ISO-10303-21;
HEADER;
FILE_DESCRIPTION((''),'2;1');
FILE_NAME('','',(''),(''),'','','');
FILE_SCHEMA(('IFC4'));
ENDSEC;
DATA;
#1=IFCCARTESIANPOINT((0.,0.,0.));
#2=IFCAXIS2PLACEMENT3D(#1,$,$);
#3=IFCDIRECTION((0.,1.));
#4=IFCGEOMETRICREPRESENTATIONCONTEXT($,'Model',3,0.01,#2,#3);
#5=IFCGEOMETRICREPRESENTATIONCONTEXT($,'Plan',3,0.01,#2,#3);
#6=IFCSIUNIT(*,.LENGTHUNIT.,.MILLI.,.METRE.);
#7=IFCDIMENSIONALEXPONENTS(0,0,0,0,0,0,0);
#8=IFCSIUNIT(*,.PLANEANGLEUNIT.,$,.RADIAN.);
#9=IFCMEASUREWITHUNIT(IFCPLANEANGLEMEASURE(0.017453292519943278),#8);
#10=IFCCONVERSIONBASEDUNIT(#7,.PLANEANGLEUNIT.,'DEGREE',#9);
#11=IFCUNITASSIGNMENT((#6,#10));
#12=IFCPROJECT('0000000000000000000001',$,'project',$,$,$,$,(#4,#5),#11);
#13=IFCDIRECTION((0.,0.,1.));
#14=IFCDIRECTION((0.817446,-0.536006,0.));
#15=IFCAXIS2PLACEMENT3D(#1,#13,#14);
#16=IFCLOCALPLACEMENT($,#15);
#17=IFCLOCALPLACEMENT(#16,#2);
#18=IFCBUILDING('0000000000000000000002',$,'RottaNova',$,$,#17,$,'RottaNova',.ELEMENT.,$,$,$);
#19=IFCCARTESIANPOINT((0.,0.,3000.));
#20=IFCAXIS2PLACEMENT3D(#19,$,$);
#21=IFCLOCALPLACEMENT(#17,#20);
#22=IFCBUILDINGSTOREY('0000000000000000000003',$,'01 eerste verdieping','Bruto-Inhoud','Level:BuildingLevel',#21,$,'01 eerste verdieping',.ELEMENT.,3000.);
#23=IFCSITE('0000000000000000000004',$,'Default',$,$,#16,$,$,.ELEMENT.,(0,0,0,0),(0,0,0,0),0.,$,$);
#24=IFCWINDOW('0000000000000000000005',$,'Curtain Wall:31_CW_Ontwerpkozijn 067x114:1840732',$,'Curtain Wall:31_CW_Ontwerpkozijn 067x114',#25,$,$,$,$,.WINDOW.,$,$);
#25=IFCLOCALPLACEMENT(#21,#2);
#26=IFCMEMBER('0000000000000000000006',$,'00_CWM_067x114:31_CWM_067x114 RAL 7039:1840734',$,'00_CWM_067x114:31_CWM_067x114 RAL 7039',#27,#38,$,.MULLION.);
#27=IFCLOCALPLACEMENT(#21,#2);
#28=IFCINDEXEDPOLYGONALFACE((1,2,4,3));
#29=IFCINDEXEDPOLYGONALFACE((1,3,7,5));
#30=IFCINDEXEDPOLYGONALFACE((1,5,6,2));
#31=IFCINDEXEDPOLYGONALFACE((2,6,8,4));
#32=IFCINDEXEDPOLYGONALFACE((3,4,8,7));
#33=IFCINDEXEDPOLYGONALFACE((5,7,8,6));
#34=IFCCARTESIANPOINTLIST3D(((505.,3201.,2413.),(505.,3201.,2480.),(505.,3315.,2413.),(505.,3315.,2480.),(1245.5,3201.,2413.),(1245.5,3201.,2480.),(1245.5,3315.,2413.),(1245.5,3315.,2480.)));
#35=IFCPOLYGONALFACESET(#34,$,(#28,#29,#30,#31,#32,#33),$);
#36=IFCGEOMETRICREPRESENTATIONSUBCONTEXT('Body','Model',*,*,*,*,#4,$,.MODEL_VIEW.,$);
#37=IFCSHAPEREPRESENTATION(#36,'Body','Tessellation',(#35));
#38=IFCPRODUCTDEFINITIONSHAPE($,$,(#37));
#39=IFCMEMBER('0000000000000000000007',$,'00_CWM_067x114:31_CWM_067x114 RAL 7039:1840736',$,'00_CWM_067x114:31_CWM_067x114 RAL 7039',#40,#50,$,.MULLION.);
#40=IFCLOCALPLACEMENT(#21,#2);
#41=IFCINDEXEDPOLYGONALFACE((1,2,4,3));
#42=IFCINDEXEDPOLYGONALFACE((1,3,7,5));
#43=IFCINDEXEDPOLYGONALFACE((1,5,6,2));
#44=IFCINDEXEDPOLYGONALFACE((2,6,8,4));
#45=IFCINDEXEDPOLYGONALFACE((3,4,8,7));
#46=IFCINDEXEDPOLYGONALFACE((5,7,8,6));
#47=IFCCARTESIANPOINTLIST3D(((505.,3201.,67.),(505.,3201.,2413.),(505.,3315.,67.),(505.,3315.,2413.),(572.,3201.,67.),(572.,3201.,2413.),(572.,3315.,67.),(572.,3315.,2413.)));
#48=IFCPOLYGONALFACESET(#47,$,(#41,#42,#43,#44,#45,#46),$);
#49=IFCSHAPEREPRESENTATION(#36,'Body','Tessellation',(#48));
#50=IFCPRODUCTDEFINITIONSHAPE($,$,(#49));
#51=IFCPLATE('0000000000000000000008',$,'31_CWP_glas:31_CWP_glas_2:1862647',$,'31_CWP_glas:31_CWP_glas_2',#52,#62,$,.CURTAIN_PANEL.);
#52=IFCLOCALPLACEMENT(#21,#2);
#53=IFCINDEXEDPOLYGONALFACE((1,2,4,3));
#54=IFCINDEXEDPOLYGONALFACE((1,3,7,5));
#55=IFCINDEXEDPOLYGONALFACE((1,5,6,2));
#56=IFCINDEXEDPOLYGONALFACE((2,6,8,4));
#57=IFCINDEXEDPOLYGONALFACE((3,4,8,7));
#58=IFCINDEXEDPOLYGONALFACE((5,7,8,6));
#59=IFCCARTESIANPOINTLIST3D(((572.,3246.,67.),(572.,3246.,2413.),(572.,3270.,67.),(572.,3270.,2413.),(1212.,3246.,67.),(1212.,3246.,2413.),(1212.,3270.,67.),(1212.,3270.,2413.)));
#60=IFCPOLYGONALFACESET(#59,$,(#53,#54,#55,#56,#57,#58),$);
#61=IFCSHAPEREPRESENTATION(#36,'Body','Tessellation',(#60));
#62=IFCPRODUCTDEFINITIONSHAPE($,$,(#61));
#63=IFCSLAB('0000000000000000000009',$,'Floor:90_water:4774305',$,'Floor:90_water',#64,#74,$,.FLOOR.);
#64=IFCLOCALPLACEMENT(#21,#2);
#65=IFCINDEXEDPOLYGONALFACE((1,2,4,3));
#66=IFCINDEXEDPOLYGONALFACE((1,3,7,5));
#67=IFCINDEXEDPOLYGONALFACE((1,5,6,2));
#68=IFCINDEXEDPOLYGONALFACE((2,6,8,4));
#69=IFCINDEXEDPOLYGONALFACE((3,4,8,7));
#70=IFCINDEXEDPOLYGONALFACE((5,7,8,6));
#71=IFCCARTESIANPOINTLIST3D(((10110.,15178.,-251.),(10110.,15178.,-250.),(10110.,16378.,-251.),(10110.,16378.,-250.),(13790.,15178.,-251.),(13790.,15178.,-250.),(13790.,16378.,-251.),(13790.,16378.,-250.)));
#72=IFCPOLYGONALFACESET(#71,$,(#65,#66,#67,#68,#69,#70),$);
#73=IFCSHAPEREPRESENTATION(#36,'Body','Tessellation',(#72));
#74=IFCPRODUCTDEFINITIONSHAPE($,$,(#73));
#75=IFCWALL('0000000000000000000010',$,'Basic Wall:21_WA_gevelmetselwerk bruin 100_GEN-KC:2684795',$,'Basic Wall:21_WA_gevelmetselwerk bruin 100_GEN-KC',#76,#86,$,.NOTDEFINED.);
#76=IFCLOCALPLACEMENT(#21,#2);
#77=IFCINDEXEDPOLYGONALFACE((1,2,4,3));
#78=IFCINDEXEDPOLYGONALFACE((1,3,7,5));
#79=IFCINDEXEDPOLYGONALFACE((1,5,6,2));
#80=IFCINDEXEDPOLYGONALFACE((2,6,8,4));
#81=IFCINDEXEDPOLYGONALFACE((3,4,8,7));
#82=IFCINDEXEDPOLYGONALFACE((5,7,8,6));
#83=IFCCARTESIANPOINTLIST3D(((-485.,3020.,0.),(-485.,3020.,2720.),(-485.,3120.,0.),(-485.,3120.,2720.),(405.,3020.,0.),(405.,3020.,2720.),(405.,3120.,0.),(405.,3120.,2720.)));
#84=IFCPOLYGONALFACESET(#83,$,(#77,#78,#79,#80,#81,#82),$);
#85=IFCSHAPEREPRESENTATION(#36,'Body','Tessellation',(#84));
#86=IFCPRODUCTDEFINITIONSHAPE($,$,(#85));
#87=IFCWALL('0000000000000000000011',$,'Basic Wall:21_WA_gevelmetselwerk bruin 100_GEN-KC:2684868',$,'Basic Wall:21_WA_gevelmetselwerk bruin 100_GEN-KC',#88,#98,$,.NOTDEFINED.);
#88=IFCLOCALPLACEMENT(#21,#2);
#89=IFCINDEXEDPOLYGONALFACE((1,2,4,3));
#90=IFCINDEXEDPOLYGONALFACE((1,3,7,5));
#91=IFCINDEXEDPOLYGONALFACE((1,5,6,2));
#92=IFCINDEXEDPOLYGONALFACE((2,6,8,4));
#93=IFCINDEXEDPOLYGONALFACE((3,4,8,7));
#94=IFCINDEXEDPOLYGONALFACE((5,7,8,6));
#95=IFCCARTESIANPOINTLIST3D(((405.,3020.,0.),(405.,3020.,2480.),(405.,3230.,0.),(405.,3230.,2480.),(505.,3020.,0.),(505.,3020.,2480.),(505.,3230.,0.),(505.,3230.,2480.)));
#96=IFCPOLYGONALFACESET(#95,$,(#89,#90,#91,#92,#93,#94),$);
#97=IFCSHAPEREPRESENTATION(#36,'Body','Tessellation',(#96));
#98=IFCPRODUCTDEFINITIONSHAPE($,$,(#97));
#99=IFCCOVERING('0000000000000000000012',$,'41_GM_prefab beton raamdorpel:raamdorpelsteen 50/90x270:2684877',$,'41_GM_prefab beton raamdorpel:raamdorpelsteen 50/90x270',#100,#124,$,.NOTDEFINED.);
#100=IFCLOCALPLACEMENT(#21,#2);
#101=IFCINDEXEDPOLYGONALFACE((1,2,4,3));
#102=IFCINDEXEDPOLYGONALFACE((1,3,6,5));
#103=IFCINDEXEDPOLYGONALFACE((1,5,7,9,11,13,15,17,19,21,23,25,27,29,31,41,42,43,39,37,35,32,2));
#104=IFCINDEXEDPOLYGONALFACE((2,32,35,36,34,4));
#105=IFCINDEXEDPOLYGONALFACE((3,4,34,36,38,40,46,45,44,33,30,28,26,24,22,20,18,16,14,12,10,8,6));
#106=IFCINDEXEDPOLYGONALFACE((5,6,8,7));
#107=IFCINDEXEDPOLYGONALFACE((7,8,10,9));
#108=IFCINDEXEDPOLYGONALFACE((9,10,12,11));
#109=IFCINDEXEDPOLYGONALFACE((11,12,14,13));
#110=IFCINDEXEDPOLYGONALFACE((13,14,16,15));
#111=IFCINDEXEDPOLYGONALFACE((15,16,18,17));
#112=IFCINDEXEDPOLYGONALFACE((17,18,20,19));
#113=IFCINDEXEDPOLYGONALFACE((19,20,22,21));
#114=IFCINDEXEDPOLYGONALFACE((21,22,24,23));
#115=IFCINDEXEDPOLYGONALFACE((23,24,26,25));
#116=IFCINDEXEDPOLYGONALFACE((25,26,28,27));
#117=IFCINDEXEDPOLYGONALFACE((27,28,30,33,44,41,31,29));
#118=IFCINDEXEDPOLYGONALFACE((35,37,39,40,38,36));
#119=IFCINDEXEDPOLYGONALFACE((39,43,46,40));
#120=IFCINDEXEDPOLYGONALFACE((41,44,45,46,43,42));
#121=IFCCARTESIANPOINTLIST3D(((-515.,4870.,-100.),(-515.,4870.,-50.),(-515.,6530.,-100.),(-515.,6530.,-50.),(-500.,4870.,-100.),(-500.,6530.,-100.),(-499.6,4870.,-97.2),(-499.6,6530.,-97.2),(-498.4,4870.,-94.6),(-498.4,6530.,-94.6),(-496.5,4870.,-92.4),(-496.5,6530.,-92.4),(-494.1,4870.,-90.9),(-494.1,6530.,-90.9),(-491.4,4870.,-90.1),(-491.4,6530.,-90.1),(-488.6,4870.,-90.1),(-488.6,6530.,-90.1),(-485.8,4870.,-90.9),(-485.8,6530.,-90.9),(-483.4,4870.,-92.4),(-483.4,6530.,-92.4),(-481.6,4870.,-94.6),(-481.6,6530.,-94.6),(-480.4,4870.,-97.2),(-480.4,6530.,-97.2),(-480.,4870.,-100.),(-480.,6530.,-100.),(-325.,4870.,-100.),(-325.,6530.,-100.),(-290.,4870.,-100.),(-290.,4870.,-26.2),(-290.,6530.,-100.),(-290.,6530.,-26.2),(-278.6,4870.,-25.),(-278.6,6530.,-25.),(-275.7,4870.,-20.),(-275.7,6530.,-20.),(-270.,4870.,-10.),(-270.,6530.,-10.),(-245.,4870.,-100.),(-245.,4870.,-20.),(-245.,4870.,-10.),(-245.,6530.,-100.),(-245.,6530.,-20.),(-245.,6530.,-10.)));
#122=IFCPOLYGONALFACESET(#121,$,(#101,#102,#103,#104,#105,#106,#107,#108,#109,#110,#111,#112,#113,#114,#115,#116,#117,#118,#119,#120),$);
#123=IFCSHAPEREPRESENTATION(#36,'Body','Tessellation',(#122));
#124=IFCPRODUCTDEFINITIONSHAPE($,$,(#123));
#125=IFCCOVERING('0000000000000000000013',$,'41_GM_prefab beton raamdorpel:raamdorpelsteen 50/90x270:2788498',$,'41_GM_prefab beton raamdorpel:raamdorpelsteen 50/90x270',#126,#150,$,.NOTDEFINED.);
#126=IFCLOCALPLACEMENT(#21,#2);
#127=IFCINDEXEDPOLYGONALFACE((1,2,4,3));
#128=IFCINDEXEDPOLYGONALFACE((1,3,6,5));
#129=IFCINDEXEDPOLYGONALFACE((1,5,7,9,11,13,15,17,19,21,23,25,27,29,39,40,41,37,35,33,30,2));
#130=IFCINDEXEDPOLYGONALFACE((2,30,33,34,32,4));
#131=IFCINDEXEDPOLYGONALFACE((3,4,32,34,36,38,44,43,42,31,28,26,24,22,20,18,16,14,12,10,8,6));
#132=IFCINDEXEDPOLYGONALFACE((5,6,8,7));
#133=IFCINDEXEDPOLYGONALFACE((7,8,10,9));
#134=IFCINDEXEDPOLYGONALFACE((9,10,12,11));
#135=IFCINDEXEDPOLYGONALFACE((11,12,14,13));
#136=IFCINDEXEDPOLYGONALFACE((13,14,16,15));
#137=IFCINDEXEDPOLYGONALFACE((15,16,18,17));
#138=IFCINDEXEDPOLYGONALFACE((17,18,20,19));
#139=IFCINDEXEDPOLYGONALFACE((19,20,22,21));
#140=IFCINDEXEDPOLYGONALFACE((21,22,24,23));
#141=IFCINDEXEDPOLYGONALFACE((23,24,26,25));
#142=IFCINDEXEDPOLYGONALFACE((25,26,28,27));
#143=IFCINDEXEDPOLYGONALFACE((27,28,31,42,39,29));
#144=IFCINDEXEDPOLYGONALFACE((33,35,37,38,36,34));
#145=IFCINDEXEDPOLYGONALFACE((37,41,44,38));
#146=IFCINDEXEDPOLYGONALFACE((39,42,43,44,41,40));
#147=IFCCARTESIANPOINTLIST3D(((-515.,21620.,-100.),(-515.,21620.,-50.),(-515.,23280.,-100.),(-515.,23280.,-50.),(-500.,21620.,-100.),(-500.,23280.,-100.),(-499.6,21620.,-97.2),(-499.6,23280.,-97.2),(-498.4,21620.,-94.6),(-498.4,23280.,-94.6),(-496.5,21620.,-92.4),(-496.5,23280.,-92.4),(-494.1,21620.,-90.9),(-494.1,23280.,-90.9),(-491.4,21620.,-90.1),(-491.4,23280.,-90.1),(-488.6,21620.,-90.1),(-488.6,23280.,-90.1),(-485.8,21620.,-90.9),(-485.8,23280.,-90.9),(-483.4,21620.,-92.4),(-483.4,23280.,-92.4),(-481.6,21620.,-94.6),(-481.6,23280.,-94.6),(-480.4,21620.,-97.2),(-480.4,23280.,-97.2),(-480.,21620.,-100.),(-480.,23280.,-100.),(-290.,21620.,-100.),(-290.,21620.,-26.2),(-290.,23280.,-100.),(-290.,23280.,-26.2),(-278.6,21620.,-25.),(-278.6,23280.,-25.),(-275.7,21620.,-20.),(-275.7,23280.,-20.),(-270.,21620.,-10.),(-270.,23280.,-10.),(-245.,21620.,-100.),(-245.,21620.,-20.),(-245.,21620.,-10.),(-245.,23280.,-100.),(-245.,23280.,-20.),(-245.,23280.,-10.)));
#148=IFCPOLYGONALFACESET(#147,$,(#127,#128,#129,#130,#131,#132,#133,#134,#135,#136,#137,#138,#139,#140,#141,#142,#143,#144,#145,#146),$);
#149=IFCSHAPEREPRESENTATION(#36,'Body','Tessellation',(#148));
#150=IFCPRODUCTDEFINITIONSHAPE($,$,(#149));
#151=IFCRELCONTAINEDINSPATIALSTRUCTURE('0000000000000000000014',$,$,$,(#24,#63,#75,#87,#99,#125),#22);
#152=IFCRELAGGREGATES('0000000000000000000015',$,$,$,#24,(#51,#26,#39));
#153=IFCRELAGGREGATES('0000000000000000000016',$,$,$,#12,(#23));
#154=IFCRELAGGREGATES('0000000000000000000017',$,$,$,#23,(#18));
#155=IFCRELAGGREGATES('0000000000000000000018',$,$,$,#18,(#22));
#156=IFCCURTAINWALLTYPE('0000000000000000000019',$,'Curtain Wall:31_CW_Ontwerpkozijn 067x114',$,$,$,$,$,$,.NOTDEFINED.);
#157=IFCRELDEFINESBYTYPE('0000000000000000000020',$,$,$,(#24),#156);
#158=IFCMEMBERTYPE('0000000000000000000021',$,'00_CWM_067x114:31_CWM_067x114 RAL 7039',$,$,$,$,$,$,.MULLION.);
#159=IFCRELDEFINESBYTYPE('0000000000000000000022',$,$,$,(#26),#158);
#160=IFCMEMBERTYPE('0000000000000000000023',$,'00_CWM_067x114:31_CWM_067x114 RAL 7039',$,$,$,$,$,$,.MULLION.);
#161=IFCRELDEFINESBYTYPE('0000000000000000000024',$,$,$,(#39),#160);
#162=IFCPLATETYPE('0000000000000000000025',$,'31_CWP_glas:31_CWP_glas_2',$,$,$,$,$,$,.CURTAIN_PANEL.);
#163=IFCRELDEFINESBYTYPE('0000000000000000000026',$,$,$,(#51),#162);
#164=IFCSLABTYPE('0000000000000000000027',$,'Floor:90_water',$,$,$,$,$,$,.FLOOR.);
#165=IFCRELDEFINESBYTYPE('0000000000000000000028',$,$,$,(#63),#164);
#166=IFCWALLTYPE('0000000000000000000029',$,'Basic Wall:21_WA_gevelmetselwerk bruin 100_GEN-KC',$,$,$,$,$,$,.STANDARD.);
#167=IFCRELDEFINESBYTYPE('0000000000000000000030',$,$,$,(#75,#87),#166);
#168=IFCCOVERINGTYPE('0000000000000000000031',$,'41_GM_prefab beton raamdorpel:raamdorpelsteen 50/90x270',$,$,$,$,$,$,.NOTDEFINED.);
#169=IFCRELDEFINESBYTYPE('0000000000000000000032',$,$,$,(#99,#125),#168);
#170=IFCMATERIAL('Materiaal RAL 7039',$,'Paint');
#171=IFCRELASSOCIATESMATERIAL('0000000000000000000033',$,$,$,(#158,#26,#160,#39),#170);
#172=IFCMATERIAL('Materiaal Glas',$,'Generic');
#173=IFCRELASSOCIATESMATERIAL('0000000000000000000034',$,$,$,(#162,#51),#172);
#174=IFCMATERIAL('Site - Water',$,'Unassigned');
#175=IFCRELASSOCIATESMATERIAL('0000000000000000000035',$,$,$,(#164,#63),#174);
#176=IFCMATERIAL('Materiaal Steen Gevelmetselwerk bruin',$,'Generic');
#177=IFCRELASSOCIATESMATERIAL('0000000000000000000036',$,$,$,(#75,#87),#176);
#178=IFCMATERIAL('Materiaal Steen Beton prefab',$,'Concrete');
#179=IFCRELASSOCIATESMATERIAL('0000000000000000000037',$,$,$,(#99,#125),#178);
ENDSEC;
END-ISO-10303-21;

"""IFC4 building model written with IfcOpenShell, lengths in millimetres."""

from ifc_helpers import new_model, entity, si_unit, converted_unit, direction, frame, origin, place, context, subcontext, project, spatial, line, arc, indexed_curve, outline, extrude, source, transform, mapped, material, type_object, type_shapes, element, aggregate, save


model = new_model("IFC4")

# Units and contexts
model_context = context("Model", 3, precision=0.01, world=origin(), true_north=direction((0.0, 1.0)))
plan_context = context("Plan", 3, precision=0.01, world=origin(), true_north=direction((0.0, 1.0)))
body_context = subcontext(model_context, "Body", "Model", "MODEL_VIEW")
ifc_project = project(units=[si_unit("LENGTHUNIT", "METRE", prefix="MILLI"), converted_unit("PLANEANGLEUNIT", "DEGREE", entity("IfcPlaneAngleMeasure", 0.017453292519943278), si_unit("PLANEANGLEUNIT", "RADIAN"), dimensions=[0, 0, 0, 0, 0, 0, 0])], contexts=[model_context, plan_context])

# Site, building, storey
site_placement = place(None, frame((0.0, 0.0, 0.0), z_axis=(0.0, 0.0, 1.0), x_axis=(0.817446, -0.536006, 0.0)))
site = spatial("IfcSite", under=ifc_project, at=site_placement, Name="Default", CompositionType="ELEMENT", RefLatitude=(0, 0, 0, 0), RefLongitude=(0, 0, 0, 0), RefElevation=0.0)
building_placement = place(site_placement, origin())
building = spatial("IfcBuilding", under=site, at=building_placement, Name="RottaNova", LongName="RottaNova", CompositionType="ELEMENT")
storey_placement = place(building_placement, frame((0.0, 0.0, 3000.0)))
storey = spatial("IfcBuildingStorey", under=building, at=storey_placement, Name="01 eerste verdieping", Description="Bruto-Inhoud", ObjectType="Level:BuildingLevel", LongName="01 eerste verdieping", CompositionType="ELEMENT", Elevation=3000.0)

# Window, members
curtain_wall_type = type_object("IfcCurtainWallType", Name="Curtain Wall:31_CW_Ontwerpkozijn 067x114", PredefinedType="NOTDEFINED")
window_placement = place(storey_placement, frame((0.0, 0.0, -3000.0)))
window = element("IfcWindow", 1, at=window_placement, inside=storey, type_object=curtain_wall_type, Name="Curtain Wall:31_CW_Ontwerpkozijn 067x114:1840732", ObjectType="Curtain Wall:31_CW_Ontwerpkozijn 067x114", PredefinedType="WINDOW")
ifc_material_1 = material(Name="Materiaal RAL 7039", Category="Paint")
member_type_1 = type_object("IfcMemberType", Name="00_CWM_067x114:31_CWM_067x114 RAL 7039", PredefinedType="MULLION", material=ifc_material_1)
shared_shape_1 = source(origin(), body_context, "Body", "SweptSolid", [
    extrude(outline(indexed_curve([(-33.5, -57.0), (33.5, -57.0), (33.5, 57.0), (-33.5, 57.0), (-33.5, -57.0)], self_intersect=False)), frame((-33.5, -57.0, -740.5), z_axis=(0.0, 0.0, 1.0), x_axis=(-1.0, 0.0, 0.0)), (0.0, 0.0, 1.0), 740.5),
])
type_shapes(member_type_1, [shared_shape_1])
member_1_placement = place(window_placement, frame((505.0, 3315.0, 5480.0), z_axis=(-1.0, 0.0, 0.0), x_axis=(0.0, 0.0, 1.0)))
member_1 = element("IfcMember", 2, at=member_1_placement, type_object=member_type_1, material=ifc_material_1, Name="00_CWM_067x114:31_CWM_067x114 RAL 7039:1840734", ObjectType="00_CWM_067x114:31_CWM_067x114 RAL 7039", PredefinedType="MULLION", context=body_context, shape_type="MappedRepresentation", body=[
    mapped(shared_shape_1, transform((0.0, 0.0, 0.0), scale=1.0)),
])
member_type_2 = type_object("IfcMemberType", Name="00_CWM_067x114:31_CWM_067x114 RAL 7039", PredefinedType="MULLION", material=ifc_material_1)
shared_shape_2 = source(origin(), body_context, "Body", "SweptSolid", [
    extrude(outline(indexed_curve([(-33.5, -57.0), (33.5, -57.0), (33.5, 57.0), (-33.5, 57.0), (-33.5, -57.0)], self_intersect=False)), frame((-33.5, -57.0, -2346.0), z_axis=(0.0, 0.0, 1.0), x_axis=(-1.0, 0.0, 0.0)), (0.0, 0.0, 1.0), 2346.0),
])
type_shapes(member_type_2, [shared_shape_2])
member_2_placement = place(window_placement, frame((505.0, 3315.0, 3067.0), z_axis=(0.0, 0.0, -1.0), x_axis=(-1.0, 0.0, 0.0)))
member_2 = element("IfcMember", 3, at=member_2_placement, type_object=member_type_2, material=ifc_material_1, Name="00_CWM_067x114:31_CWM_067x114 RAL 7039:1840736", ObjectType="00_CWM_067x114:31_CWM_067x114 RAL 7039", PredefinedType="MULLION", context=body_context, shape_type="MappedRepresentation", body=[
    mapped(shared_shape_2, transform((0.0, 0.0, 0.0), scale=1.0)),
])

# Plate
ifc_material_2 = material(Name="Materiaal Glas", Category="Generic")
plate_type = type_object("IfcPlateType", Name="31_CWP_glas:31_CWP_glas_2", PredefinedType="CURTAIN_PANEL", material=ifc_material_2)
shared_shape_3 = source(origin(), body_context, "Body", "SweptSolid", [
    extrude(outline(indexed_curve([(-12.0, -320.0), (12.0, -320.0), (12.0, 320.0), (-12.0, 320.0), (-12.0, -320.0)], self_intersect=False)), frame((0.0, 57.0, 0.0), z_axis=(0.0, 0.0, 1.0), x_axis=(0.0, 1.0, 0.0)), (0.0, 0.0, 1.0), 2346.0),
])
type_shapes(plate_type, [shared_shape_3])
plate_placement = place(window_placement, frame((892.0, 3315.0, 3067.0), z_axis=(0.0, 0.0, 1.0), x_axis=(-1.0, 0.0, 0.0)))
plate = element("IfcPlate", 4, at=plate_placement, type_object=plate_type, material=ifc_material_2, Name="31_CWP_glas:31_CWP_glas_2:1862647", ObjectType="31_CWP_glas:31_CWP_glas_2", PredefinedType="CURTAIN_PANEL", context=body_context, shape_type="MappedRepresentation", body=[
    mapped(shared_shape_3, transform((0.0, 0.0, 0.0), scale=1.0)),
])
aggregate(window, [plate, member_1, member_2])

# Slab
ifc_material_3 = material(Name="Site - Water", Category="Unassigned")
slab_type_1 = type_object("IfcSlabType", Name="Floor:90_water", PredefinedType="FLOOR", material=ifc_material_3)
slab_1_placement = place(storey_placement, origin())
element("IfcSlab", 5, at=slab_1_placement, inside=storey, type_object=slab_type_1, material=ifc_material_3, Name="Floor:90_water:4774305", ObjectType="Floor:90_water", PredefinedType="FLOOR", context=body_context, shape_type="SweptSolid", body=[
    extrude(outline(indexed_curve([(-600.0, -1840.0), (600.0, -1840.0), (600.0, 1840.0), (-600.0, 1840.0), (-600.0, -1840.0)], self_intersect=False)), frame((11950.0, 15778.0, -250.0), z_axis=(0.0, 0.0, -1.0), x_axis=(0.0, 1.0, 0.0)), (0.0, 0.0, 1.0), 1.0),
])

# Walls
ifc_material_4 = material(Name="Materiaal Steen Gevelmetselwerk bruin", Category="Generic")
wall_type = type_object("IfcWallType", Name="Basic Wall:21_WA_gevelmetselwerk bruin 100_GEN-KC", PredefinedType="STANDARD")
wall_1_placement = place(storey_placement, frame((405.0, 3070.0, 0.0), z_axis=(0.0, 0.0, 1.0), x_axis=(-1.0, 0.0, 0.0)))
element("IfcWall", 6, at=wall_1_placement, inside=storey, type_object=wall_type, material=ifc_material_4, Name="Basic Wall:21_WA_gevelmetselwerk bruin 100_GEN-KC:2684795", ObjectType="Basic Wall:21_WA_gevelmetselwerk bruin 100_GEN-KC", PredefinedType="NOTDEFINED", context=body_context, shape_type="SweptSolid", body=[
    extrude(outline(indexed_curve([(890.0, 50.0), (0.0, 50.0), (0.0, -50.0), (890.0, -50.0), (890.0, 50.0)], self_intersect=False)), origin(), (0.0, 0.0, 1.0), 2720.0),
])
wall_2_placement = place(storey_placement, frame((455.0, 3230.0, 0.0), z_axis=(0.0, 0.0, 1.0), x_axis=(0.0, -1.0, 0.0)))
element("IfcWall", 7, at=wall_2_placement, inside=storey, type_object=wall_type, material=ifc_material_4, Name="Basic Wall:21_WA_gevelmetselwerk bruin 100_GEN-KC:2684868", ObjectType="Basic Wall:21_WA_gevelmetselwerk bruin 100_GEN-KC", PredefinedType="NOTDEFINED", context=body_context, shape_type="SweptSolid", body=[
    extrude(outline(indexed_curve([(210.0, 50.0), (0.0, 50.0), (0.0, -50.0), (210.0, -50.0), (210.0, 50.0)], self_intersect=False)), origin(), (0.0, 0.0, 1.0), 2480.0),
])

# Coverings
ifc_material_5 = material(Name="Materiaal Steen Beton prefab", Category="Concrete")
covering_type_1 = type_object("IfcCoveringType", Name="41_GM_prefab beton raamdorpel:raamdorpelsteen 50/90x270", PredefinedType="NOTDEFINED")
covering_1_placement = place(storey_placement, origin())
element("IfcCovering", 8, at=covering_1_placement, inside=storey, type_object=covering_type_1, material=ifc_material_5, Name="41_GM_prefab beton raamdorpel:raamdorpelsteen 50/90x270:2684877", ObjectType="41_GM_prefab beton raamdorpel:raamdorpelsteen 50/90x270", PredefinedType="NOTDEFINED", context=body_context, shape_type="SweptSolid", body=[
    extrude(outline(indexed_curve([(74.2, -48.6), (99.2, -48.6), (99.2, -38.6), (99.2, 41.4), (54.2, 41.4), (19.2, 41.4), (-135.8, 41.4), (-145.8, 31.4), (-155.8, 41.4), (-170.8, 41.4), (-170.8, -8.6), (54.2, -32.4), (65.5, -33.6), (68.4, -38.6)], segments=[line(1, 2, 3, 4, 5, 6, 7), arc(7, 8, 9), line(9, 10, 11, 12, 13, 14, 1)], self_intersect=False)), frame((-344.2, 4870.0, -58.6), z_axis=(0.0, 1.0, 0.0), x_axis=(1.0, 0.0, 0.0)), (0.0, 0.0, 1.0), 1660.0),
])
covering_2_placement = place(storey_placement, origin())
element("IfcCovering", 9, at=covering_2_placement, inside=storey, type_object=covering_type_1, material=ifc_material_5, Name="41_GM_prefab beton raamdorpel:raamdorpelsteen 50/90x270:2788498", ObjectType="41_GM_prefab beton raamdorpel:raamdorpelsteen 50/90x270", PredefinedType="NOTDEFINED", context=body_context, shape_type="SweptSolid", body=[
    extrude(outline(indexed_curve([(75.8, -45.1), (100.8, -45.1), (100.8, -35.1), (100.8, 44.9), (55.8, 44.9), (-134.2, 44.9), (-144.2, 34.9), (-154.2, 44.9), (-169.2, 44.9), (-169.2, -5.1), (55.8, -28.9), (67.1, -30.1), (70.0, -35.1)], segments=[line(1, 2, 3, 4, 5, 6), arc(6, 7, 8), line(8, 9, 10, 11, 12, 13, 1)], self_intersect=False)), frame((-345.8, 21620.0, -55.1), z_axis=(0.0, 1.0, 0.0), x_axis=(1.0, 0.0, 0.0)), (0.0, 0.0, 1.0), 1660.0),
])

save(model, "model.ifc")
